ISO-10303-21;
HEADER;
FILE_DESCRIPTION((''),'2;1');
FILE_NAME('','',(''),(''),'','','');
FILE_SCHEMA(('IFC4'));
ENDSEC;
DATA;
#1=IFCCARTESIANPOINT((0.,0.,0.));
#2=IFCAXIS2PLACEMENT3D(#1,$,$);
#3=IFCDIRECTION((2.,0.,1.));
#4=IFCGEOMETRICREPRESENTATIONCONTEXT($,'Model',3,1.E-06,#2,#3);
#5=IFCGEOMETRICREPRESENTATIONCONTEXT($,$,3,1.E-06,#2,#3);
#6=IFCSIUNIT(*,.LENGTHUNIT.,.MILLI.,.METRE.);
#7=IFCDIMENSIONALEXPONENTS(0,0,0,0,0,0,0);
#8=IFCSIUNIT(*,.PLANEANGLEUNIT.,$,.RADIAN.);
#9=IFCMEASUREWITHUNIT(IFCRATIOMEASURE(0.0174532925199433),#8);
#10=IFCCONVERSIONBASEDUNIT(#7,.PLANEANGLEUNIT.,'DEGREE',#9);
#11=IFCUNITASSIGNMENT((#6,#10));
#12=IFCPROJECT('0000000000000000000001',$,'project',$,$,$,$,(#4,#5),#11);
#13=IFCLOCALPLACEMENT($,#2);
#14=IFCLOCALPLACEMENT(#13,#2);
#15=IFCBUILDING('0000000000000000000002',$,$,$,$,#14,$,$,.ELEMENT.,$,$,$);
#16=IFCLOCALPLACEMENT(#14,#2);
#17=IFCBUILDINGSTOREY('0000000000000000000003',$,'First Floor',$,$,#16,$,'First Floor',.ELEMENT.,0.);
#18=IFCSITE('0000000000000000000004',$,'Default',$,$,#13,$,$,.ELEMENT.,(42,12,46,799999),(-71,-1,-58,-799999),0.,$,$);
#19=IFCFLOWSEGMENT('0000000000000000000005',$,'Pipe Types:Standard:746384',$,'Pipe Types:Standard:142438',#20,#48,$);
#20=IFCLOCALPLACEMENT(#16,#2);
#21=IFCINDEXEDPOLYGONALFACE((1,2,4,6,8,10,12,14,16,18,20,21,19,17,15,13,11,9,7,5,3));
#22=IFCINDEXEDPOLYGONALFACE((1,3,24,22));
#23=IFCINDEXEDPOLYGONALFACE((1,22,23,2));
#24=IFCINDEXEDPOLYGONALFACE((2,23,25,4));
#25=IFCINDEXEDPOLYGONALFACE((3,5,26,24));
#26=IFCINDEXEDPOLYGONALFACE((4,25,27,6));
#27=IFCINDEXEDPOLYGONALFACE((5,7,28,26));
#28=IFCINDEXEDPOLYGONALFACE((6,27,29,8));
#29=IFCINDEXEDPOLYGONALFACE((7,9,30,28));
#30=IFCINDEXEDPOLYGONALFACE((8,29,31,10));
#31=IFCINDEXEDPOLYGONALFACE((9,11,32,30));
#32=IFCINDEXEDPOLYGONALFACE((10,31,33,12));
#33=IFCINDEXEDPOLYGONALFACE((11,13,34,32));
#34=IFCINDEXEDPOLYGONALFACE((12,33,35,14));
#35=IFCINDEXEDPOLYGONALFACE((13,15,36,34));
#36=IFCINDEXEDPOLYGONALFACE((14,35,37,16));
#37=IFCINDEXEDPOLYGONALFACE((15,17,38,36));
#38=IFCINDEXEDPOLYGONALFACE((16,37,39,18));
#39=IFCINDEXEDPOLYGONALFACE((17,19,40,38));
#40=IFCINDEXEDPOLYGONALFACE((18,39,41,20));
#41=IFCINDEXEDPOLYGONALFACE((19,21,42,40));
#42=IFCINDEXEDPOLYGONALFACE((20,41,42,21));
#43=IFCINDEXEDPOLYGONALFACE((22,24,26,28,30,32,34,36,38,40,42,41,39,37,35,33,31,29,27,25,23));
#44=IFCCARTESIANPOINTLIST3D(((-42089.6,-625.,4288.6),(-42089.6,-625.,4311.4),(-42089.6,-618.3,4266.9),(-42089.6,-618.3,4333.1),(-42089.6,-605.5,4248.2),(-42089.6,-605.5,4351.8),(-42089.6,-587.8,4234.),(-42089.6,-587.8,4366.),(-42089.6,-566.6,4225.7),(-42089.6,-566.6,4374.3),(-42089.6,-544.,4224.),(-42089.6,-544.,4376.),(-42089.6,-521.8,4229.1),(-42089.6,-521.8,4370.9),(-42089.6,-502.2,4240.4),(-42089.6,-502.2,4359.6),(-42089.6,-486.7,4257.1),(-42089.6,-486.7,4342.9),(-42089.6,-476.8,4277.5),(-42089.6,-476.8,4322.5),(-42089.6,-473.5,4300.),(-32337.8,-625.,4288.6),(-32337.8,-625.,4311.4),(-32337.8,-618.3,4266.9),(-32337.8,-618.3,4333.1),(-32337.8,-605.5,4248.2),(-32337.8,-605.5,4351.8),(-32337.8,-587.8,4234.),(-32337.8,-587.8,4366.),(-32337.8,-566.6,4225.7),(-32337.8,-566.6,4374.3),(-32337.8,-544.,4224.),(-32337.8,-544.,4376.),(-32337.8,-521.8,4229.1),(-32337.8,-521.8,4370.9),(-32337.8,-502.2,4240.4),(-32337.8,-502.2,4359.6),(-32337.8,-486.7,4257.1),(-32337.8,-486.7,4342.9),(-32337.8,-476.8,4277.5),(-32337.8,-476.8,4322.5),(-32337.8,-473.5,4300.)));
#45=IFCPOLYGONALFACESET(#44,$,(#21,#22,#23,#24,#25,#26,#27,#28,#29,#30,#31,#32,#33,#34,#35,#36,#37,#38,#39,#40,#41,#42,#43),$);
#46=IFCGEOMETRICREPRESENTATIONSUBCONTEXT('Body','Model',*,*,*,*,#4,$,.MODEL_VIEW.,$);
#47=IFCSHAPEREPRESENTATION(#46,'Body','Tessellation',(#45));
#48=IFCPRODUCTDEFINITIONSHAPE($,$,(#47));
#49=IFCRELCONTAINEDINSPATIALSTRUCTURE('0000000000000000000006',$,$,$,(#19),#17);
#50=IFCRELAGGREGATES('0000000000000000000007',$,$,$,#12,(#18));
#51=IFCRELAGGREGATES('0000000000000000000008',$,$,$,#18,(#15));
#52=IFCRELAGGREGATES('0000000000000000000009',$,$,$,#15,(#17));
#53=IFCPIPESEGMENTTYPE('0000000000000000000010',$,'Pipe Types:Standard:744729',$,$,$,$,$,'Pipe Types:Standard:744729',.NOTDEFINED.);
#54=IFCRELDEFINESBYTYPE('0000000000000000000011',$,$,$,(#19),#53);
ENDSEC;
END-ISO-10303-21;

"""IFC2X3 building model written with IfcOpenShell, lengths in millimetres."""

from ifc_helpers import new_model, entity, si_unit, converted_unit, direction, frame, frame_2d, origin, place, context, subcontext, project, spatial, circle, extrude, type_object, element, save


model = new_model("IFC2X3")

# Units and contexts
model_context = context("Model", 3, precision=1e-06, world=origin(), true_north=direction((2.0, 0.0, 1.0)))
context_of_model = context(None, 3, precision=1e-06, world=origin(), true_north=direction((2.0, 0.0, 1.0)))
body_context = subcontext(model_context, "Body", "Model", "MODEL_VIEW")
ifc_project = project(units=[si_unit("LENGTHUNIT", "METRE", prefix="MILLI"), converted_unit("PLANEANGLEUNIT", "DEGREE", entity("IfcRatioMeasure", 0.0174532925199433), si_unit("PLANEANGLEUNIT", "RADIAN"), dimensions=[0, 0, 0, 0, 0, 0, 0])], contexts=[model_context, context_of_model])

# Site, building, storey
site_placement = place(None, origin())
site = spatial("IfcSite", under=ifc_project, at=site_placement, Name="Default", CompositionType="ELEMENT", RefLatitude=(42, 12, 46, 799999), RefLongitude=(-71, -1, -58, -799999), RefElevation=0.0)
building_placement = place(site_placement, origin())
building = spatial("IfcBuilding", under=site, at=building_placement, CompositionType="ELEMENT")
storey_placement = place(building_placement, origin())
storey = spatial("IfcBuildingStorey", under=building, at=storey_placement, Name="First Floor", LongName="First Floor", CompositionType="ELEMENT", Elevation=0.0)

# Flow segment
pipe_segment_type = type_object("IfcPipeSegmentType", Name="Pipe Types:Standard:744729", ElementType="Pipe Types:Standard:744729", PredefinedType="NOTDEFINED")
flow_segment_1_placement = place(storey_placement, origin())
element("IfcFlowSegment", 1, at=flow_segment_1_placement, inside=storey, type_object=pipe_segment_type, Name="Pipe Types:Standard:746384", ObjectType="Pipe Types:Standard:142438", context=body_context, shape_type="SweptSolid", body=[
    extrude(circle(Radius=76.2, at=frame_2d((0.0, 0.0), x_axis=(1.0, 0.0))), frame((-42089.6, -549.7, 4300.0), z_axis=(1.0, 0.0, 0.0), x_axis=(0.0, 1.0, 0.0)), (0.0, 0.0, 1.0), 9751.7),
])

save(model, "model.ifc")
